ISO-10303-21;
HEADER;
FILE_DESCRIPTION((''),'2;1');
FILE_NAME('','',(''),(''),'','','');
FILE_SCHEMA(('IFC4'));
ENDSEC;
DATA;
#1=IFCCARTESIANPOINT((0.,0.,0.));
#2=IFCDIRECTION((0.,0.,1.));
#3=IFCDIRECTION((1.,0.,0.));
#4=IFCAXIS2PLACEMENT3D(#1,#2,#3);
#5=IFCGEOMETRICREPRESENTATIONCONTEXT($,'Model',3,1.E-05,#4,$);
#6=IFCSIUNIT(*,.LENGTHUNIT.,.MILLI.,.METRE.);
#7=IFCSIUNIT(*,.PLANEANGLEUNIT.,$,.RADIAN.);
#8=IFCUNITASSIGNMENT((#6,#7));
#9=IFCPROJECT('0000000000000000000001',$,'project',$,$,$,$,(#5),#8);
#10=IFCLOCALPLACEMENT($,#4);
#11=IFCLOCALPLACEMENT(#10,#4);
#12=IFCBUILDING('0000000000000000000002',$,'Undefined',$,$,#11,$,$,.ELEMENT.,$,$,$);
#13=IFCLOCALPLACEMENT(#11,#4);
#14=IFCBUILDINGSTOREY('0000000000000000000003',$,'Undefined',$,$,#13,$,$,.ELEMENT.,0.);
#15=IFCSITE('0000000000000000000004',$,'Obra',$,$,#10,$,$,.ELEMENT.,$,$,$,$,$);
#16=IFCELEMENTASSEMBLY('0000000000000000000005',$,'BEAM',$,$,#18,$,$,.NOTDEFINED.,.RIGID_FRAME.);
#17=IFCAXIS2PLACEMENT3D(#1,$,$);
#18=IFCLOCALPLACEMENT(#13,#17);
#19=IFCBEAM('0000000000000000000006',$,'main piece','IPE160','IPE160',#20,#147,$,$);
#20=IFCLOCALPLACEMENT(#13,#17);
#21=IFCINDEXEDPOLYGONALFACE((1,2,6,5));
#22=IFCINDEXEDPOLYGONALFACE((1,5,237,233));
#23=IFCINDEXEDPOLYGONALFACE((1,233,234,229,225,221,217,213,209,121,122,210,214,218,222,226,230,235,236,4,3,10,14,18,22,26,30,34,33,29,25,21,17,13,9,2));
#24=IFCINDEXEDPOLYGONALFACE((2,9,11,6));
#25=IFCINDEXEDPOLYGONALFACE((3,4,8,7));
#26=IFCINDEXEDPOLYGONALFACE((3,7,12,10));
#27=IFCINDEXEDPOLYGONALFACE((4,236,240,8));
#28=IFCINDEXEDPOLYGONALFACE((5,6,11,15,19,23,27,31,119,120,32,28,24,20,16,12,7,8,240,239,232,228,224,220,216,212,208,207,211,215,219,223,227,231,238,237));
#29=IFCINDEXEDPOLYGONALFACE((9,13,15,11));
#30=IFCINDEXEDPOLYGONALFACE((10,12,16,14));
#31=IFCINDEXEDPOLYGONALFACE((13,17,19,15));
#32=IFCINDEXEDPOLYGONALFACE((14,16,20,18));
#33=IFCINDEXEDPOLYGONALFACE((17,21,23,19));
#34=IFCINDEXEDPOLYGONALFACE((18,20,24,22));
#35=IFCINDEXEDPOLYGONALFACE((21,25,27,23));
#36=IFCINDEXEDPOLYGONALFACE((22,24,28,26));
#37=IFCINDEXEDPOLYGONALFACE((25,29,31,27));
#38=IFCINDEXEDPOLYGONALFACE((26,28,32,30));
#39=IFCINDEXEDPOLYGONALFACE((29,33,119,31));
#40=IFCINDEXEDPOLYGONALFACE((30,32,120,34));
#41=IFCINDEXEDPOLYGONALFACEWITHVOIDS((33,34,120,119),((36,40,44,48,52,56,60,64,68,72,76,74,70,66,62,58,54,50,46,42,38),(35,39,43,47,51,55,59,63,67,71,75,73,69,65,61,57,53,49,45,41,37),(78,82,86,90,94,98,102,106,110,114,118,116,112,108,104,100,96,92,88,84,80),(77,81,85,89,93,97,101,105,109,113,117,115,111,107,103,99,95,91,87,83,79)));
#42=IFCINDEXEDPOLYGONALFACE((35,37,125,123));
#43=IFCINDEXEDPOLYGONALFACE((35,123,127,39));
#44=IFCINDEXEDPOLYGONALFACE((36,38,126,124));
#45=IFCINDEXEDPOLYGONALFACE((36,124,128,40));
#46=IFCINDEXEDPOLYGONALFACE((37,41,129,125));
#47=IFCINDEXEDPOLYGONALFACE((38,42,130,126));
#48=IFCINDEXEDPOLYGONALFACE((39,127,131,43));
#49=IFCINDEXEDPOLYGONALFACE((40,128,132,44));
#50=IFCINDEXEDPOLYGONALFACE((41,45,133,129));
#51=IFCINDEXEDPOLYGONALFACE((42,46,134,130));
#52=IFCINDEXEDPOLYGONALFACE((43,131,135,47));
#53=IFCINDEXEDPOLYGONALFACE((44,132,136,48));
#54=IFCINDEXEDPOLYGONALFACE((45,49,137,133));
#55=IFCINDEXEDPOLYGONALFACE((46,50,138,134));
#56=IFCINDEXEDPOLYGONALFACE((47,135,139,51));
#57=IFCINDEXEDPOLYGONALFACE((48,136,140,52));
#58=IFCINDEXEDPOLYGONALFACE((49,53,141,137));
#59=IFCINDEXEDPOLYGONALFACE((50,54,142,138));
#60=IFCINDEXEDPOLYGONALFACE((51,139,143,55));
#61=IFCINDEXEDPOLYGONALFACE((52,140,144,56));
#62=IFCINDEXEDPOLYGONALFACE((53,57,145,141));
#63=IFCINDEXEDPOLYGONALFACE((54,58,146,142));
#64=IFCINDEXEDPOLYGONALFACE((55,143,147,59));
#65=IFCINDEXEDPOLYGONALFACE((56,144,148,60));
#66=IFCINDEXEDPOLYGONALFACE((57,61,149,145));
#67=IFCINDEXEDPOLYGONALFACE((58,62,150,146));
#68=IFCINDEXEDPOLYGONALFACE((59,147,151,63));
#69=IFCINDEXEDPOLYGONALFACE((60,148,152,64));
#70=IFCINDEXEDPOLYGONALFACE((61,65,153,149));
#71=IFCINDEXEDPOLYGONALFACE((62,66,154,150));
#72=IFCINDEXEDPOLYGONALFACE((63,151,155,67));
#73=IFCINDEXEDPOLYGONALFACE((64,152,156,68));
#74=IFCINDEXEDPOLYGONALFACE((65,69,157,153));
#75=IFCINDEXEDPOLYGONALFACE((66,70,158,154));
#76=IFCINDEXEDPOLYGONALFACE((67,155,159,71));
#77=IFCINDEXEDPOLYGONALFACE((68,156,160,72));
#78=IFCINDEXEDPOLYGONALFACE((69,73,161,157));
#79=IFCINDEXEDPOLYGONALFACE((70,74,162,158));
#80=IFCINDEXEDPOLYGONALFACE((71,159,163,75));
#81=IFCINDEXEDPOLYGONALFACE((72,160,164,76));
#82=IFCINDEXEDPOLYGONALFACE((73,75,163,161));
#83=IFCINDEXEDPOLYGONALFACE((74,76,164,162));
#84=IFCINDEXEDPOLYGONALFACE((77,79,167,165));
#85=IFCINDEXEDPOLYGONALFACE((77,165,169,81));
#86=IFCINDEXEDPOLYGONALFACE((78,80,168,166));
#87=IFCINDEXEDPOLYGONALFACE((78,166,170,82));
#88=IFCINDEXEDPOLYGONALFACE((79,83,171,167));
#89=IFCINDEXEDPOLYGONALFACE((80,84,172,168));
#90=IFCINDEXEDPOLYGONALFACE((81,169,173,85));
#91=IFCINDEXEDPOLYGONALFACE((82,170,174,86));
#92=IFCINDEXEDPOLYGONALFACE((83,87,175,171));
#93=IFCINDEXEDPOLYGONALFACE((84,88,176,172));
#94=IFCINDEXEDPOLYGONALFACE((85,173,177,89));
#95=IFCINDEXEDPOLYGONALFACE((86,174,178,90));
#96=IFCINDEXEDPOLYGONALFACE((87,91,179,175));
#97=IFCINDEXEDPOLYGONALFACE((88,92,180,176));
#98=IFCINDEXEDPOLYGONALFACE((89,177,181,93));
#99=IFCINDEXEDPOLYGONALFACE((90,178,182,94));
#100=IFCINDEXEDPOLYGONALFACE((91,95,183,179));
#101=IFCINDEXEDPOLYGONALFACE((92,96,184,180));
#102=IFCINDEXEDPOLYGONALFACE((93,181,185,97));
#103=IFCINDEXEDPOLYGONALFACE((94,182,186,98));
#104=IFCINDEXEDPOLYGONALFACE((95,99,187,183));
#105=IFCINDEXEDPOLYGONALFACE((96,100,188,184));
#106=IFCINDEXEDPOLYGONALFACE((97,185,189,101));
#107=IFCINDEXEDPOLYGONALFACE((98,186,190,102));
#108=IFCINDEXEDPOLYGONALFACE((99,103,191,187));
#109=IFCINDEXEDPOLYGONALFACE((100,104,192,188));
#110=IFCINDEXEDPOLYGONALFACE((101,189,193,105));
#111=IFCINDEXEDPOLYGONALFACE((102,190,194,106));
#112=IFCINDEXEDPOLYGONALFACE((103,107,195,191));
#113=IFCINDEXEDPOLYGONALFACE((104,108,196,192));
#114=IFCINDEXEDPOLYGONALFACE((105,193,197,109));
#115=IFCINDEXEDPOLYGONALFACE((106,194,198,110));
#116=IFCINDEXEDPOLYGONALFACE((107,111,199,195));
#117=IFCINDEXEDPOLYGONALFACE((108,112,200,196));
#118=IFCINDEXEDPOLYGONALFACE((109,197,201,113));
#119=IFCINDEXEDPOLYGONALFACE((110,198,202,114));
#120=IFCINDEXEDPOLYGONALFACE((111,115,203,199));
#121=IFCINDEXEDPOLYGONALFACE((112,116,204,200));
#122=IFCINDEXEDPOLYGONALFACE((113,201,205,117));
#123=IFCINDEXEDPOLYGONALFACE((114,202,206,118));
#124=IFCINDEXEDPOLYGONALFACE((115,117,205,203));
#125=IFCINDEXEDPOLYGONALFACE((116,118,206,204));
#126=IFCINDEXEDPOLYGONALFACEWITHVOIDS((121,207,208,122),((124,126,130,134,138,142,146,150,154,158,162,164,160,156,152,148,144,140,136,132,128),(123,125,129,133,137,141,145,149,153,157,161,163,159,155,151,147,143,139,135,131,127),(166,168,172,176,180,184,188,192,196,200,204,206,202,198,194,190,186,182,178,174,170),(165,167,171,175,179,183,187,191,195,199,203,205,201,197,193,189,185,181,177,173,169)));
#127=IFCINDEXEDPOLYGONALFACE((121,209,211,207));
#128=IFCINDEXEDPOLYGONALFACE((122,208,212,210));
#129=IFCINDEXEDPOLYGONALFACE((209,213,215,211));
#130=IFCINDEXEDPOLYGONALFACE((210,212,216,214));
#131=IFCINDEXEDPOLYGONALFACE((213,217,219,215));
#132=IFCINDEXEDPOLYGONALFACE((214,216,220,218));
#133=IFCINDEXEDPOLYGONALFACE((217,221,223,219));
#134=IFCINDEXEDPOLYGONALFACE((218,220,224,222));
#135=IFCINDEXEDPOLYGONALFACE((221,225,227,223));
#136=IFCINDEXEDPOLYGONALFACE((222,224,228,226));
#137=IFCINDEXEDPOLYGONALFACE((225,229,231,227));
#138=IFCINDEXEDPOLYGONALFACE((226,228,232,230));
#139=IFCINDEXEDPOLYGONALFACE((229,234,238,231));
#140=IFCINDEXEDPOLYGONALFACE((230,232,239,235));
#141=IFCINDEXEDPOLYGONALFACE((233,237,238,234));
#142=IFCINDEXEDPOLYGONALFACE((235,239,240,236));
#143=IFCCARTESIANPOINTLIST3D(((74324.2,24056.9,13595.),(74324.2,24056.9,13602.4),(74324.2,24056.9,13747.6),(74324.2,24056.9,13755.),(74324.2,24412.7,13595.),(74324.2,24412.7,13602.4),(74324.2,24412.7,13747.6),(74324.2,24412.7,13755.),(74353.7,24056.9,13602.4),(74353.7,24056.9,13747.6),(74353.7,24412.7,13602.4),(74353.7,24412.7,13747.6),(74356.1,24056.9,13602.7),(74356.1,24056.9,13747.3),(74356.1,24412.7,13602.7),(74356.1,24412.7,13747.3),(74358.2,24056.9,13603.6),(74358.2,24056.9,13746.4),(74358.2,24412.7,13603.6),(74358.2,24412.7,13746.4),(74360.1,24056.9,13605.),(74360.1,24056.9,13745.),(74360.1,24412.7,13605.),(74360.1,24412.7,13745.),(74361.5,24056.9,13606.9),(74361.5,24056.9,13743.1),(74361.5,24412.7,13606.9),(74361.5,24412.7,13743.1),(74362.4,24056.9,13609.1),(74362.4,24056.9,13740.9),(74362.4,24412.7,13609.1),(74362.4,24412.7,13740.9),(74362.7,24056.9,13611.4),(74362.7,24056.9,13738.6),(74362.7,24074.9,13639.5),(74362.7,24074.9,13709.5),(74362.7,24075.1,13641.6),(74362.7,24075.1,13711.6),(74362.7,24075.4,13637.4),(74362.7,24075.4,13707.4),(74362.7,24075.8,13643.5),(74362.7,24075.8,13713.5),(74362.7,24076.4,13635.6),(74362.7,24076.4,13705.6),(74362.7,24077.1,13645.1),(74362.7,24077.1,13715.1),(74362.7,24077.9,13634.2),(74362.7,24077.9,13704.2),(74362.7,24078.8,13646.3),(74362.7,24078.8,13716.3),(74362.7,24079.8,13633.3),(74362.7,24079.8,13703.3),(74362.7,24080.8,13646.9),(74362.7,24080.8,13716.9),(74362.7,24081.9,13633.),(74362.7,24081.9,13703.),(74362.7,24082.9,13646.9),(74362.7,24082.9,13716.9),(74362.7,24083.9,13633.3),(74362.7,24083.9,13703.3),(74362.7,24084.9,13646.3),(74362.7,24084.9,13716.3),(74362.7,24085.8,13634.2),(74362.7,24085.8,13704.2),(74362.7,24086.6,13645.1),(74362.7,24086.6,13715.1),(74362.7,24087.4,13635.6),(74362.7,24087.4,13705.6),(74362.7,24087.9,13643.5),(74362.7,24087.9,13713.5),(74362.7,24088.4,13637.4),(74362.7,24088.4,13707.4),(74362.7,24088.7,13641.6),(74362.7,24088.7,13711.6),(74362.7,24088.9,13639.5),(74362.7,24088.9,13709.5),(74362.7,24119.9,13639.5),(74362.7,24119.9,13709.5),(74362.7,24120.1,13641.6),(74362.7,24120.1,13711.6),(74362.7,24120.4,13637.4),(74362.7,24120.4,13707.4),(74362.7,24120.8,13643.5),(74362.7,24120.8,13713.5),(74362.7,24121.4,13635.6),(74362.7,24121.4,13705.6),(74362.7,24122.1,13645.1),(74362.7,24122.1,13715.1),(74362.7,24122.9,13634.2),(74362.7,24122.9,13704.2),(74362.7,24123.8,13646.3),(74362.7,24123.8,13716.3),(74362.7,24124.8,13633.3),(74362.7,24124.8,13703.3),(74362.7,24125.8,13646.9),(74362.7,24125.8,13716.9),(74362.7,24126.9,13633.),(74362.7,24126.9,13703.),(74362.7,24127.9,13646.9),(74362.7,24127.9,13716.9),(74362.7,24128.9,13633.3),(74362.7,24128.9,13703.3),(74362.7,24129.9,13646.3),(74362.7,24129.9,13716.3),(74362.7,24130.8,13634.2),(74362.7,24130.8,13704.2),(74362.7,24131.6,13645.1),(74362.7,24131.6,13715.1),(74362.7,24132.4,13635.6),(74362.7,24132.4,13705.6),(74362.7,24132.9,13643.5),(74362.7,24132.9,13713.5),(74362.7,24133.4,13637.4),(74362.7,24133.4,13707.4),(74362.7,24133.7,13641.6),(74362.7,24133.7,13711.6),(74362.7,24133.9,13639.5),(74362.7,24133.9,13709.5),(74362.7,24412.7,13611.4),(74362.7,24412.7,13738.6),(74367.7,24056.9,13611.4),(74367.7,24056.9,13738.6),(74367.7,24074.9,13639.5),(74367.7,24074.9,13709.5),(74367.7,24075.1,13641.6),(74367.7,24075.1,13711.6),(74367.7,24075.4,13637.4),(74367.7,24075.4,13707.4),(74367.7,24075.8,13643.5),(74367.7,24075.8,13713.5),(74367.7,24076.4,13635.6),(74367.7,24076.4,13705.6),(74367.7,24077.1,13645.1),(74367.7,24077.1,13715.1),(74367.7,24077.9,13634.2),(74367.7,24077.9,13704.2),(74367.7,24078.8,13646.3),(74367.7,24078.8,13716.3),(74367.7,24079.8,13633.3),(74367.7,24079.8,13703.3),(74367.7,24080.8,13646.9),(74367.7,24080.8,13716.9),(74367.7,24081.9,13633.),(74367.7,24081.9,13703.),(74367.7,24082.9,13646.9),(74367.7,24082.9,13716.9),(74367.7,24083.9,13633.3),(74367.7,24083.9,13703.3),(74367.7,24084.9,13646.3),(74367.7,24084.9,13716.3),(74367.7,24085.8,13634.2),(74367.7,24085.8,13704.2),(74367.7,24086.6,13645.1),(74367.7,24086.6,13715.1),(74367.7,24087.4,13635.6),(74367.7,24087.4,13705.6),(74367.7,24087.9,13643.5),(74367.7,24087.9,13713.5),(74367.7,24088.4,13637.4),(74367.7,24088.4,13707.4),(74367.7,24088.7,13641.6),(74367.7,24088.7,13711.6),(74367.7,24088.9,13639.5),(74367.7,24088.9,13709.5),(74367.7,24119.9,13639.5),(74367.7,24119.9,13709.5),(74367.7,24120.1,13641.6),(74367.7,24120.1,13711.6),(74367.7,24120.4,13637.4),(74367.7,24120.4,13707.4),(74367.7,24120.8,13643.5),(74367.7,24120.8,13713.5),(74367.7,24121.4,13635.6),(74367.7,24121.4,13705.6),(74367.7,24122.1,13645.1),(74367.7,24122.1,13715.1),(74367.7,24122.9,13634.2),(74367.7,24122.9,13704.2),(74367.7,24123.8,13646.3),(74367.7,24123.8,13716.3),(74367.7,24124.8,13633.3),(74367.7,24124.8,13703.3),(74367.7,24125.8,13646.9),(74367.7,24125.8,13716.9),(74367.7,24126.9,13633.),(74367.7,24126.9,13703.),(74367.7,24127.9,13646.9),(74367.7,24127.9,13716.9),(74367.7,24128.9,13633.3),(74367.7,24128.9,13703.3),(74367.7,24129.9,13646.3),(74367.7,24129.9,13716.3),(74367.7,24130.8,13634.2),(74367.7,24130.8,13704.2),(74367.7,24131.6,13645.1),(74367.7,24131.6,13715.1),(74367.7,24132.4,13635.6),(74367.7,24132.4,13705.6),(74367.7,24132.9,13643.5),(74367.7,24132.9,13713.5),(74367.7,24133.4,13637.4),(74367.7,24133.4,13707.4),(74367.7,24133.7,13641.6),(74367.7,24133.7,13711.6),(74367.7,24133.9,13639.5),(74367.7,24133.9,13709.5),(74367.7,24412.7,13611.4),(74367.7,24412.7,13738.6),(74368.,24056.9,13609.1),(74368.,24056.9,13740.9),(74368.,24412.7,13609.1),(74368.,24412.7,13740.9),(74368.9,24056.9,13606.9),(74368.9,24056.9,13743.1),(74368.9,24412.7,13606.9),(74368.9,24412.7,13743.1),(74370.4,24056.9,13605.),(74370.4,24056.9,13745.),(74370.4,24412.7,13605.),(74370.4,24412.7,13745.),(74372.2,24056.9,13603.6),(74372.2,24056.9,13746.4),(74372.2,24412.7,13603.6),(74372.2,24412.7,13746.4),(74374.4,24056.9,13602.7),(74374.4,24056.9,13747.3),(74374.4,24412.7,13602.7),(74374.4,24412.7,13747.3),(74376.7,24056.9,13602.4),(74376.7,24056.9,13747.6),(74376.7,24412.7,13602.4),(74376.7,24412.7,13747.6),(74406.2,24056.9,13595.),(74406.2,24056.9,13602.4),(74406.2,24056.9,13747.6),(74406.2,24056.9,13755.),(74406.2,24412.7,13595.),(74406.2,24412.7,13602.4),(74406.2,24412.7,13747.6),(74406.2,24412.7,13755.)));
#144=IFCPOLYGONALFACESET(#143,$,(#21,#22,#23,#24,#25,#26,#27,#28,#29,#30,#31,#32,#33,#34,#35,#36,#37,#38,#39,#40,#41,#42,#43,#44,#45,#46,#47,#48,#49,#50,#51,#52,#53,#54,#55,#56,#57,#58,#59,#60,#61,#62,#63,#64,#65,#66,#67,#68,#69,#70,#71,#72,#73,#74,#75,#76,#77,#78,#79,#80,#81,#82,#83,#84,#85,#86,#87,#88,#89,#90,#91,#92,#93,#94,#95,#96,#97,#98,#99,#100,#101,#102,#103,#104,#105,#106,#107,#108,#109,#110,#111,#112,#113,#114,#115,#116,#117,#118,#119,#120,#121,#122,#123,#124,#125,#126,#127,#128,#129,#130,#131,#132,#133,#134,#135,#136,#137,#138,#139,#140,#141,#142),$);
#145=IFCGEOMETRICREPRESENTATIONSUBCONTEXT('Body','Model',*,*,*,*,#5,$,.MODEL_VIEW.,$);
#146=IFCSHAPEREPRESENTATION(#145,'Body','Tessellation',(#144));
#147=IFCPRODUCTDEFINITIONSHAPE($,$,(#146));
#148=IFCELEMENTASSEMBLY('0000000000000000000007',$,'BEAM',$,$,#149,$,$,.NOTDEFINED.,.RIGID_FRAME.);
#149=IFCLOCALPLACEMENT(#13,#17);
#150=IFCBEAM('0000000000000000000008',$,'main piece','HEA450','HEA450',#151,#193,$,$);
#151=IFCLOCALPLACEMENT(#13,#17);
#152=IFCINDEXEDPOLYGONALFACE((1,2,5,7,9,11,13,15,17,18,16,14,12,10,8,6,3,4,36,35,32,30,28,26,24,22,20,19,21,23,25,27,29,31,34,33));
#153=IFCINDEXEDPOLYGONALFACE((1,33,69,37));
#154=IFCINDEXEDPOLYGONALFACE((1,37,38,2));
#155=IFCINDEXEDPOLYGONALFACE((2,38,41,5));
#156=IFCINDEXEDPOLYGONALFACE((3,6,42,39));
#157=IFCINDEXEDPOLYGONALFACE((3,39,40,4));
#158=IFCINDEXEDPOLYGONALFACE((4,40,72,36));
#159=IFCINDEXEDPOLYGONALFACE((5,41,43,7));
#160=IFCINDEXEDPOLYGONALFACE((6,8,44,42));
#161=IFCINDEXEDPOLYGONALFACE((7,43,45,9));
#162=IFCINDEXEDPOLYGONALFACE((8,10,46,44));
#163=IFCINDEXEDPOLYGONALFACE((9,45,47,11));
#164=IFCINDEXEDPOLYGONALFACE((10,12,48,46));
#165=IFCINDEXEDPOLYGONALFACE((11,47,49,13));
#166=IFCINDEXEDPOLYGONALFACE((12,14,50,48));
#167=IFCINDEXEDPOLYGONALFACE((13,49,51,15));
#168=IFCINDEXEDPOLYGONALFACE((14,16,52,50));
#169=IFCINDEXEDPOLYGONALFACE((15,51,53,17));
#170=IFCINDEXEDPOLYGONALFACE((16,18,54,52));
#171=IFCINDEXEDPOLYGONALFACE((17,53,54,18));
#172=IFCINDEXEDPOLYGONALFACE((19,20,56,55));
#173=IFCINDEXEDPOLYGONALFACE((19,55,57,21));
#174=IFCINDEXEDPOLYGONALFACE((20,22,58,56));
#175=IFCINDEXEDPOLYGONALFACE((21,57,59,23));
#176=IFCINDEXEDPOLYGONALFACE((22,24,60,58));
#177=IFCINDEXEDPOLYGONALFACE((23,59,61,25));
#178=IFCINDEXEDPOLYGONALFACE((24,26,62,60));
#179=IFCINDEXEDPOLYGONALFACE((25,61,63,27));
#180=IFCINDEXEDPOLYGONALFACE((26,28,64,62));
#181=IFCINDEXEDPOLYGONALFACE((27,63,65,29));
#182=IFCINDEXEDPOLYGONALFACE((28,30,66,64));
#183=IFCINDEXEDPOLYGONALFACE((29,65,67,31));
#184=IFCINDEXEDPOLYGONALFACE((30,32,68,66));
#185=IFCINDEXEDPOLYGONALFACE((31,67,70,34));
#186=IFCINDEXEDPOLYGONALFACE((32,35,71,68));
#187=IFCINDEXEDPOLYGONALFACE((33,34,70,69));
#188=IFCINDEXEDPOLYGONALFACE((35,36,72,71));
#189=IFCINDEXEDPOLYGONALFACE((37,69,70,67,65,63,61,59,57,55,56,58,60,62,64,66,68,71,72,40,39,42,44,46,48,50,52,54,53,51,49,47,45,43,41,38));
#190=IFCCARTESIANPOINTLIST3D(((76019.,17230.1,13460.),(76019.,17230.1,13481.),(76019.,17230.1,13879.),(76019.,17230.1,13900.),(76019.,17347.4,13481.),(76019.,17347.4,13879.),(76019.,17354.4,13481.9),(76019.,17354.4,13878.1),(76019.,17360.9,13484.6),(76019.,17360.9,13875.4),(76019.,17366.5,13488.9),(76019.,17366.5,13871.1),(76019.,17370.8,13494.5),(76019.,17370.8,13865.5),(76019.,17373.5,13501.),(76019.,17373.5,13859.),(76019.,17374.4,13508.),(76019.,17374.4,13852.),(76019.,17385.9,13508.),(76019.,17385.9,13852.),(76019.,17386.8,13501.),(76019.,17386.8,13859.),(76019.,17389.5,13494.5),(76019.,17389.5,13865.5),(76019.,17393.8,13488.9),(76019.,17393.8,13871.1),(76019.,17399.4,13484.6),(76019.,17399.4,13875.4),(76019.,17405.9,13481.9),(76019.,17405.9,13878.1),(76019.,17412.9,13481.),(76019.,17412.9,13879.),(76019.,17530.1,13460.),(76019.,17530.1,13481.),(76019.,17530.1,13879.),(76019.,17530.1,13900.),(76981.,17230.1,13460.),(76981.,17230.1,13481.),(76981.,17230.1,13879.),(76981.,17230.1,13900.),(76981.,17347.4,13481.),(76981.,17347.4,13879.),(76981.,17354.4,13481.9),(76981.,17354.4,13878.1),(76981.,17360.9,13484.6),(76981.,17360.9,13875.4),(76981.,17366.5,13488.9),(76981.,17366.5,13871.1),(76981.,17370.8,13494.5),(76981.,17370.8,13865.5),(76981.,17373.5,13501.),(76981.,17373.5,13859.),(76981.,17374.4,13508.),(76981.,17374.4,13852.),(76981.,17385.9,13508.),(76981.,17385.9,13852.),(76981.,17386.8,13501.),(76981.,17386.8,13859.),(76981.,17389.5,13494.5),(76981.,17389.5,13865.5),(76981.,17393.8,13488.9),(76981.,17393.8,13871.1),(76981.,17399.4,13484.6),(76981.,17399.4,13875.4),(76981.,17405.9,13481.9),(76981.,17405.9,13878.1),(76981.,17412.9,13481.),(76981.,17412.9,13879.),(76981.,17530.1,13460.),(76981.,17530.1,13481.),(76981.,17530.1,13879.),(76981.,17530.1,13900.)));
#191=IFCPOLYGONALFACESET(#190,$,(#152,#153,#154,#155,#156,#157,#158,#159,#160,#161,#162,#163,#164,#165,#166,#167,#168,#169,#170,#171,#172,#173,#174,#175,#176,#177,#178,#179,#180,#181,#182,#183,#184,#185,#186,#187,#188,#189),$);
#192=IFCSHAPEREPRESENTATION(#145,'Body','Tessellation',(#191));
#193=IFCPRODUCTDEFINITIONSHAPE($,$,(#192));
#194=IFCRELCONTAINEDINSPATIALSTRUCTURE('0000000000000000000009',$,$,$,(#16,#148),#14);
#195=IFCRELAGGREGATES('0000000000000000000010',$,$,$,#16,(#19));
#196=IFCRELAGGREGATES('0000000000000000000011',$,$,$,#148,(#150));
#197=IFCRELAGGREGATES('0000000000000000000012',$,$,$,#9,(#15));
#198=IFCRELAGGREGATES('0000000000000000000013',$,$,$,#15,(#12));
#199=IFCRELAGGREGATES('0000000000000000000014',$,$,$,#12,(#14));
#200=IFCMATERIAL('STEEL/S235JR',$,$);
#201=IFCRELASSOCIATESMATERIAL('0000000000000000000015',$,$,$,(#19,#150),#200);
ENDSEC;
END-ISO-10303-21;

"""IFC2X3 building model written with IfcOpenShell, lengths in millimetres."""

from ifc_helpers import new_model, si_unit, frame, origin_with_axes, origin_2d_with_axis, place, context, subcontext, project, spatial, circle, i_section, extrude, clip, halfspace, source, transform, mapped, material, element, aggregate, save


model = new_model("IFC2X3")

# Units and contexts
model_context = context("Model", 3, precision=1e-05, world=origin_with_axes())
body_context = subcontext(model_context, "Body", "Model", "MODEL_VIEW")
ifc_project = project(units=[si_unit("LENGTHUNIT", "METRE", prefix="MILLI"), si_unit("PLANEANGLEUNIT", "RADIAN")], contexts=[model_context])

# Site, building, storey
site_placement = place(None, origin_with_axes())
site = spatial("IfcSite", under=ifc_project, at=site_placement, Name="Obra", CompositionType="ELEMENT")
building_placement = place(site_placement, origin_with_axes())
building = spatial("IfcBuilding", under=site, at=building_placement, Name="Undefined", CompositionType="ELEMENT")
storey_placement = place(building_placement, origin_with_axes())
storey = spatial("IfcBuildingStorey", under=building, at=storey_placement, Name="Undefined", CompositionType="ELEMENT", Elevation=0.0)

# Shared definitions
ifc_material_1 = material(Name="STEEL/S235JR")

# Element assembly, beam, opening
assembly_1_placement = place(storey_placement, origin_with_axes())
assembly_1 = element("IfcElementAssembly", 1, at=assembly_1_placement, inside=storey, Name="BEAM", AssemblyPlace="NOTDEFINED", PredefinedType="RIGID_FRAME")
beam_1_placement = place(assembly_1_placement, frame((74365.2, 23901.0, 13675.0), z_axis=(0.0, 0.0, 1.0), x_axis=(0.0, 1.0, 0.0)))
beam_1 = element("IfcBeam", 2, at=beam_1_placement, material=ifc_material_1, Name="main piece", Description="IPE160", ObjectType="IPE160", context=body_context, shape_type="Clipping", body=[
    clip(extrude(i_section(OverallWidth=82.0, OverallDepth=160.0, WebThickness=5.0, FlangeThickness=7.4, FilletRadius=9.0, at=origin_2d_with_axis()), frame((511.7, 0.0, 0.0), z_axis=(-1.0, 0.0, 0.0), x_axis=(0.0, -1.0, 0.0)), (0.0, 0.0, 1.0), 355.8), halfspace(frame((155.9, 0.0, -180.0), z_axis=(1.0, 0.0, 0.0), x_axis=(0.0, -1.0, 0.0)), True)),
])
shared_shape_1 = source(origin_with_axes(), body_context, "Body", "SweptSolid", [
    extrude(circle(Radius=7.0, at=origin_2d_with_axis()), frame((0.0, -2.6, 0.0), z_axis=(0.0, 1.0, 0.0), x_axis=(1.0, 0.0, 0.0)), (0.0, 0.0, 1.0), 5.2),
])
opening_1_placement = place(assembly_1_placement, frame((74365.2, 24056.9, 13735.0), z_axis=(0.0, 1.0, 0.0), x_axis=(0.0, 0.0, -1.0)))
element("IfcOpeningElement", 3, at=opening_1_placement, cuts=beam_1, ObjectType="Opening", context=body_context, shape_type="MappedRepresentation", body=[
    mapped(shared_shape_1, transform((25.0, 0.0, 25.0))),
    mapped(shared_shape_1, transform((25.0, 0.0, 70.0))),
    mapped(shared_shape_1, transform((95.0, 0.0, 25.0))),
    mapped(shared_shape_1, transform((95.0, 0.0, 70.0))),
])
aggregate(assembly_1, [beam_1])

# Element assembly, beam
assembly_2_placement = place(storey_placement, origin_with_axes())
assembly_2 = element("IfcElementAssembly", 4, at=assembly_2_placement, inside=storey, Name="BEAM", AssemblyPlace="NOTDEFINED", PredefinedType="RIGID_FRAME")
beam_2_placement = place(assembly_2_placement, frame((76019.0, 17380.1, 13680.0), z_axis=(0.0, 0.0, 1.0), x_axis=(1.0, 0.0, 0.0)))
beam_2 = element("IfcBeam", 5, at=beam_2_placement, material=ifc_material_1, Name="main piece", Description="HEA450", ObjectType="HEA450", context=body_context, shape_type="Clipping", body=[
    clip(extrude(i_section(OverallWidth=300.0, OverallDepth=440.0, WebThickness=11.5, FlangeThickness=21.0, FilletRadius=27.0, at=origin_2d_with_axis()), frame((962.0, 0.0, 0.0), z_axis=(-1.0, 0.0, 0.0), x_axis=(0.0, -1.0, 0.0)), (0.0, 0.0, 1.0), 962.0), halfspace(frame((962.0, 0.0, -220.0), z_axis=(-1.0, 0.0, 0.0), x_axis=(0.0, 1.0, 0.0)), True)),
])

aggregate(assembly_2, [beam_2])

save(model, "model.ifc")
